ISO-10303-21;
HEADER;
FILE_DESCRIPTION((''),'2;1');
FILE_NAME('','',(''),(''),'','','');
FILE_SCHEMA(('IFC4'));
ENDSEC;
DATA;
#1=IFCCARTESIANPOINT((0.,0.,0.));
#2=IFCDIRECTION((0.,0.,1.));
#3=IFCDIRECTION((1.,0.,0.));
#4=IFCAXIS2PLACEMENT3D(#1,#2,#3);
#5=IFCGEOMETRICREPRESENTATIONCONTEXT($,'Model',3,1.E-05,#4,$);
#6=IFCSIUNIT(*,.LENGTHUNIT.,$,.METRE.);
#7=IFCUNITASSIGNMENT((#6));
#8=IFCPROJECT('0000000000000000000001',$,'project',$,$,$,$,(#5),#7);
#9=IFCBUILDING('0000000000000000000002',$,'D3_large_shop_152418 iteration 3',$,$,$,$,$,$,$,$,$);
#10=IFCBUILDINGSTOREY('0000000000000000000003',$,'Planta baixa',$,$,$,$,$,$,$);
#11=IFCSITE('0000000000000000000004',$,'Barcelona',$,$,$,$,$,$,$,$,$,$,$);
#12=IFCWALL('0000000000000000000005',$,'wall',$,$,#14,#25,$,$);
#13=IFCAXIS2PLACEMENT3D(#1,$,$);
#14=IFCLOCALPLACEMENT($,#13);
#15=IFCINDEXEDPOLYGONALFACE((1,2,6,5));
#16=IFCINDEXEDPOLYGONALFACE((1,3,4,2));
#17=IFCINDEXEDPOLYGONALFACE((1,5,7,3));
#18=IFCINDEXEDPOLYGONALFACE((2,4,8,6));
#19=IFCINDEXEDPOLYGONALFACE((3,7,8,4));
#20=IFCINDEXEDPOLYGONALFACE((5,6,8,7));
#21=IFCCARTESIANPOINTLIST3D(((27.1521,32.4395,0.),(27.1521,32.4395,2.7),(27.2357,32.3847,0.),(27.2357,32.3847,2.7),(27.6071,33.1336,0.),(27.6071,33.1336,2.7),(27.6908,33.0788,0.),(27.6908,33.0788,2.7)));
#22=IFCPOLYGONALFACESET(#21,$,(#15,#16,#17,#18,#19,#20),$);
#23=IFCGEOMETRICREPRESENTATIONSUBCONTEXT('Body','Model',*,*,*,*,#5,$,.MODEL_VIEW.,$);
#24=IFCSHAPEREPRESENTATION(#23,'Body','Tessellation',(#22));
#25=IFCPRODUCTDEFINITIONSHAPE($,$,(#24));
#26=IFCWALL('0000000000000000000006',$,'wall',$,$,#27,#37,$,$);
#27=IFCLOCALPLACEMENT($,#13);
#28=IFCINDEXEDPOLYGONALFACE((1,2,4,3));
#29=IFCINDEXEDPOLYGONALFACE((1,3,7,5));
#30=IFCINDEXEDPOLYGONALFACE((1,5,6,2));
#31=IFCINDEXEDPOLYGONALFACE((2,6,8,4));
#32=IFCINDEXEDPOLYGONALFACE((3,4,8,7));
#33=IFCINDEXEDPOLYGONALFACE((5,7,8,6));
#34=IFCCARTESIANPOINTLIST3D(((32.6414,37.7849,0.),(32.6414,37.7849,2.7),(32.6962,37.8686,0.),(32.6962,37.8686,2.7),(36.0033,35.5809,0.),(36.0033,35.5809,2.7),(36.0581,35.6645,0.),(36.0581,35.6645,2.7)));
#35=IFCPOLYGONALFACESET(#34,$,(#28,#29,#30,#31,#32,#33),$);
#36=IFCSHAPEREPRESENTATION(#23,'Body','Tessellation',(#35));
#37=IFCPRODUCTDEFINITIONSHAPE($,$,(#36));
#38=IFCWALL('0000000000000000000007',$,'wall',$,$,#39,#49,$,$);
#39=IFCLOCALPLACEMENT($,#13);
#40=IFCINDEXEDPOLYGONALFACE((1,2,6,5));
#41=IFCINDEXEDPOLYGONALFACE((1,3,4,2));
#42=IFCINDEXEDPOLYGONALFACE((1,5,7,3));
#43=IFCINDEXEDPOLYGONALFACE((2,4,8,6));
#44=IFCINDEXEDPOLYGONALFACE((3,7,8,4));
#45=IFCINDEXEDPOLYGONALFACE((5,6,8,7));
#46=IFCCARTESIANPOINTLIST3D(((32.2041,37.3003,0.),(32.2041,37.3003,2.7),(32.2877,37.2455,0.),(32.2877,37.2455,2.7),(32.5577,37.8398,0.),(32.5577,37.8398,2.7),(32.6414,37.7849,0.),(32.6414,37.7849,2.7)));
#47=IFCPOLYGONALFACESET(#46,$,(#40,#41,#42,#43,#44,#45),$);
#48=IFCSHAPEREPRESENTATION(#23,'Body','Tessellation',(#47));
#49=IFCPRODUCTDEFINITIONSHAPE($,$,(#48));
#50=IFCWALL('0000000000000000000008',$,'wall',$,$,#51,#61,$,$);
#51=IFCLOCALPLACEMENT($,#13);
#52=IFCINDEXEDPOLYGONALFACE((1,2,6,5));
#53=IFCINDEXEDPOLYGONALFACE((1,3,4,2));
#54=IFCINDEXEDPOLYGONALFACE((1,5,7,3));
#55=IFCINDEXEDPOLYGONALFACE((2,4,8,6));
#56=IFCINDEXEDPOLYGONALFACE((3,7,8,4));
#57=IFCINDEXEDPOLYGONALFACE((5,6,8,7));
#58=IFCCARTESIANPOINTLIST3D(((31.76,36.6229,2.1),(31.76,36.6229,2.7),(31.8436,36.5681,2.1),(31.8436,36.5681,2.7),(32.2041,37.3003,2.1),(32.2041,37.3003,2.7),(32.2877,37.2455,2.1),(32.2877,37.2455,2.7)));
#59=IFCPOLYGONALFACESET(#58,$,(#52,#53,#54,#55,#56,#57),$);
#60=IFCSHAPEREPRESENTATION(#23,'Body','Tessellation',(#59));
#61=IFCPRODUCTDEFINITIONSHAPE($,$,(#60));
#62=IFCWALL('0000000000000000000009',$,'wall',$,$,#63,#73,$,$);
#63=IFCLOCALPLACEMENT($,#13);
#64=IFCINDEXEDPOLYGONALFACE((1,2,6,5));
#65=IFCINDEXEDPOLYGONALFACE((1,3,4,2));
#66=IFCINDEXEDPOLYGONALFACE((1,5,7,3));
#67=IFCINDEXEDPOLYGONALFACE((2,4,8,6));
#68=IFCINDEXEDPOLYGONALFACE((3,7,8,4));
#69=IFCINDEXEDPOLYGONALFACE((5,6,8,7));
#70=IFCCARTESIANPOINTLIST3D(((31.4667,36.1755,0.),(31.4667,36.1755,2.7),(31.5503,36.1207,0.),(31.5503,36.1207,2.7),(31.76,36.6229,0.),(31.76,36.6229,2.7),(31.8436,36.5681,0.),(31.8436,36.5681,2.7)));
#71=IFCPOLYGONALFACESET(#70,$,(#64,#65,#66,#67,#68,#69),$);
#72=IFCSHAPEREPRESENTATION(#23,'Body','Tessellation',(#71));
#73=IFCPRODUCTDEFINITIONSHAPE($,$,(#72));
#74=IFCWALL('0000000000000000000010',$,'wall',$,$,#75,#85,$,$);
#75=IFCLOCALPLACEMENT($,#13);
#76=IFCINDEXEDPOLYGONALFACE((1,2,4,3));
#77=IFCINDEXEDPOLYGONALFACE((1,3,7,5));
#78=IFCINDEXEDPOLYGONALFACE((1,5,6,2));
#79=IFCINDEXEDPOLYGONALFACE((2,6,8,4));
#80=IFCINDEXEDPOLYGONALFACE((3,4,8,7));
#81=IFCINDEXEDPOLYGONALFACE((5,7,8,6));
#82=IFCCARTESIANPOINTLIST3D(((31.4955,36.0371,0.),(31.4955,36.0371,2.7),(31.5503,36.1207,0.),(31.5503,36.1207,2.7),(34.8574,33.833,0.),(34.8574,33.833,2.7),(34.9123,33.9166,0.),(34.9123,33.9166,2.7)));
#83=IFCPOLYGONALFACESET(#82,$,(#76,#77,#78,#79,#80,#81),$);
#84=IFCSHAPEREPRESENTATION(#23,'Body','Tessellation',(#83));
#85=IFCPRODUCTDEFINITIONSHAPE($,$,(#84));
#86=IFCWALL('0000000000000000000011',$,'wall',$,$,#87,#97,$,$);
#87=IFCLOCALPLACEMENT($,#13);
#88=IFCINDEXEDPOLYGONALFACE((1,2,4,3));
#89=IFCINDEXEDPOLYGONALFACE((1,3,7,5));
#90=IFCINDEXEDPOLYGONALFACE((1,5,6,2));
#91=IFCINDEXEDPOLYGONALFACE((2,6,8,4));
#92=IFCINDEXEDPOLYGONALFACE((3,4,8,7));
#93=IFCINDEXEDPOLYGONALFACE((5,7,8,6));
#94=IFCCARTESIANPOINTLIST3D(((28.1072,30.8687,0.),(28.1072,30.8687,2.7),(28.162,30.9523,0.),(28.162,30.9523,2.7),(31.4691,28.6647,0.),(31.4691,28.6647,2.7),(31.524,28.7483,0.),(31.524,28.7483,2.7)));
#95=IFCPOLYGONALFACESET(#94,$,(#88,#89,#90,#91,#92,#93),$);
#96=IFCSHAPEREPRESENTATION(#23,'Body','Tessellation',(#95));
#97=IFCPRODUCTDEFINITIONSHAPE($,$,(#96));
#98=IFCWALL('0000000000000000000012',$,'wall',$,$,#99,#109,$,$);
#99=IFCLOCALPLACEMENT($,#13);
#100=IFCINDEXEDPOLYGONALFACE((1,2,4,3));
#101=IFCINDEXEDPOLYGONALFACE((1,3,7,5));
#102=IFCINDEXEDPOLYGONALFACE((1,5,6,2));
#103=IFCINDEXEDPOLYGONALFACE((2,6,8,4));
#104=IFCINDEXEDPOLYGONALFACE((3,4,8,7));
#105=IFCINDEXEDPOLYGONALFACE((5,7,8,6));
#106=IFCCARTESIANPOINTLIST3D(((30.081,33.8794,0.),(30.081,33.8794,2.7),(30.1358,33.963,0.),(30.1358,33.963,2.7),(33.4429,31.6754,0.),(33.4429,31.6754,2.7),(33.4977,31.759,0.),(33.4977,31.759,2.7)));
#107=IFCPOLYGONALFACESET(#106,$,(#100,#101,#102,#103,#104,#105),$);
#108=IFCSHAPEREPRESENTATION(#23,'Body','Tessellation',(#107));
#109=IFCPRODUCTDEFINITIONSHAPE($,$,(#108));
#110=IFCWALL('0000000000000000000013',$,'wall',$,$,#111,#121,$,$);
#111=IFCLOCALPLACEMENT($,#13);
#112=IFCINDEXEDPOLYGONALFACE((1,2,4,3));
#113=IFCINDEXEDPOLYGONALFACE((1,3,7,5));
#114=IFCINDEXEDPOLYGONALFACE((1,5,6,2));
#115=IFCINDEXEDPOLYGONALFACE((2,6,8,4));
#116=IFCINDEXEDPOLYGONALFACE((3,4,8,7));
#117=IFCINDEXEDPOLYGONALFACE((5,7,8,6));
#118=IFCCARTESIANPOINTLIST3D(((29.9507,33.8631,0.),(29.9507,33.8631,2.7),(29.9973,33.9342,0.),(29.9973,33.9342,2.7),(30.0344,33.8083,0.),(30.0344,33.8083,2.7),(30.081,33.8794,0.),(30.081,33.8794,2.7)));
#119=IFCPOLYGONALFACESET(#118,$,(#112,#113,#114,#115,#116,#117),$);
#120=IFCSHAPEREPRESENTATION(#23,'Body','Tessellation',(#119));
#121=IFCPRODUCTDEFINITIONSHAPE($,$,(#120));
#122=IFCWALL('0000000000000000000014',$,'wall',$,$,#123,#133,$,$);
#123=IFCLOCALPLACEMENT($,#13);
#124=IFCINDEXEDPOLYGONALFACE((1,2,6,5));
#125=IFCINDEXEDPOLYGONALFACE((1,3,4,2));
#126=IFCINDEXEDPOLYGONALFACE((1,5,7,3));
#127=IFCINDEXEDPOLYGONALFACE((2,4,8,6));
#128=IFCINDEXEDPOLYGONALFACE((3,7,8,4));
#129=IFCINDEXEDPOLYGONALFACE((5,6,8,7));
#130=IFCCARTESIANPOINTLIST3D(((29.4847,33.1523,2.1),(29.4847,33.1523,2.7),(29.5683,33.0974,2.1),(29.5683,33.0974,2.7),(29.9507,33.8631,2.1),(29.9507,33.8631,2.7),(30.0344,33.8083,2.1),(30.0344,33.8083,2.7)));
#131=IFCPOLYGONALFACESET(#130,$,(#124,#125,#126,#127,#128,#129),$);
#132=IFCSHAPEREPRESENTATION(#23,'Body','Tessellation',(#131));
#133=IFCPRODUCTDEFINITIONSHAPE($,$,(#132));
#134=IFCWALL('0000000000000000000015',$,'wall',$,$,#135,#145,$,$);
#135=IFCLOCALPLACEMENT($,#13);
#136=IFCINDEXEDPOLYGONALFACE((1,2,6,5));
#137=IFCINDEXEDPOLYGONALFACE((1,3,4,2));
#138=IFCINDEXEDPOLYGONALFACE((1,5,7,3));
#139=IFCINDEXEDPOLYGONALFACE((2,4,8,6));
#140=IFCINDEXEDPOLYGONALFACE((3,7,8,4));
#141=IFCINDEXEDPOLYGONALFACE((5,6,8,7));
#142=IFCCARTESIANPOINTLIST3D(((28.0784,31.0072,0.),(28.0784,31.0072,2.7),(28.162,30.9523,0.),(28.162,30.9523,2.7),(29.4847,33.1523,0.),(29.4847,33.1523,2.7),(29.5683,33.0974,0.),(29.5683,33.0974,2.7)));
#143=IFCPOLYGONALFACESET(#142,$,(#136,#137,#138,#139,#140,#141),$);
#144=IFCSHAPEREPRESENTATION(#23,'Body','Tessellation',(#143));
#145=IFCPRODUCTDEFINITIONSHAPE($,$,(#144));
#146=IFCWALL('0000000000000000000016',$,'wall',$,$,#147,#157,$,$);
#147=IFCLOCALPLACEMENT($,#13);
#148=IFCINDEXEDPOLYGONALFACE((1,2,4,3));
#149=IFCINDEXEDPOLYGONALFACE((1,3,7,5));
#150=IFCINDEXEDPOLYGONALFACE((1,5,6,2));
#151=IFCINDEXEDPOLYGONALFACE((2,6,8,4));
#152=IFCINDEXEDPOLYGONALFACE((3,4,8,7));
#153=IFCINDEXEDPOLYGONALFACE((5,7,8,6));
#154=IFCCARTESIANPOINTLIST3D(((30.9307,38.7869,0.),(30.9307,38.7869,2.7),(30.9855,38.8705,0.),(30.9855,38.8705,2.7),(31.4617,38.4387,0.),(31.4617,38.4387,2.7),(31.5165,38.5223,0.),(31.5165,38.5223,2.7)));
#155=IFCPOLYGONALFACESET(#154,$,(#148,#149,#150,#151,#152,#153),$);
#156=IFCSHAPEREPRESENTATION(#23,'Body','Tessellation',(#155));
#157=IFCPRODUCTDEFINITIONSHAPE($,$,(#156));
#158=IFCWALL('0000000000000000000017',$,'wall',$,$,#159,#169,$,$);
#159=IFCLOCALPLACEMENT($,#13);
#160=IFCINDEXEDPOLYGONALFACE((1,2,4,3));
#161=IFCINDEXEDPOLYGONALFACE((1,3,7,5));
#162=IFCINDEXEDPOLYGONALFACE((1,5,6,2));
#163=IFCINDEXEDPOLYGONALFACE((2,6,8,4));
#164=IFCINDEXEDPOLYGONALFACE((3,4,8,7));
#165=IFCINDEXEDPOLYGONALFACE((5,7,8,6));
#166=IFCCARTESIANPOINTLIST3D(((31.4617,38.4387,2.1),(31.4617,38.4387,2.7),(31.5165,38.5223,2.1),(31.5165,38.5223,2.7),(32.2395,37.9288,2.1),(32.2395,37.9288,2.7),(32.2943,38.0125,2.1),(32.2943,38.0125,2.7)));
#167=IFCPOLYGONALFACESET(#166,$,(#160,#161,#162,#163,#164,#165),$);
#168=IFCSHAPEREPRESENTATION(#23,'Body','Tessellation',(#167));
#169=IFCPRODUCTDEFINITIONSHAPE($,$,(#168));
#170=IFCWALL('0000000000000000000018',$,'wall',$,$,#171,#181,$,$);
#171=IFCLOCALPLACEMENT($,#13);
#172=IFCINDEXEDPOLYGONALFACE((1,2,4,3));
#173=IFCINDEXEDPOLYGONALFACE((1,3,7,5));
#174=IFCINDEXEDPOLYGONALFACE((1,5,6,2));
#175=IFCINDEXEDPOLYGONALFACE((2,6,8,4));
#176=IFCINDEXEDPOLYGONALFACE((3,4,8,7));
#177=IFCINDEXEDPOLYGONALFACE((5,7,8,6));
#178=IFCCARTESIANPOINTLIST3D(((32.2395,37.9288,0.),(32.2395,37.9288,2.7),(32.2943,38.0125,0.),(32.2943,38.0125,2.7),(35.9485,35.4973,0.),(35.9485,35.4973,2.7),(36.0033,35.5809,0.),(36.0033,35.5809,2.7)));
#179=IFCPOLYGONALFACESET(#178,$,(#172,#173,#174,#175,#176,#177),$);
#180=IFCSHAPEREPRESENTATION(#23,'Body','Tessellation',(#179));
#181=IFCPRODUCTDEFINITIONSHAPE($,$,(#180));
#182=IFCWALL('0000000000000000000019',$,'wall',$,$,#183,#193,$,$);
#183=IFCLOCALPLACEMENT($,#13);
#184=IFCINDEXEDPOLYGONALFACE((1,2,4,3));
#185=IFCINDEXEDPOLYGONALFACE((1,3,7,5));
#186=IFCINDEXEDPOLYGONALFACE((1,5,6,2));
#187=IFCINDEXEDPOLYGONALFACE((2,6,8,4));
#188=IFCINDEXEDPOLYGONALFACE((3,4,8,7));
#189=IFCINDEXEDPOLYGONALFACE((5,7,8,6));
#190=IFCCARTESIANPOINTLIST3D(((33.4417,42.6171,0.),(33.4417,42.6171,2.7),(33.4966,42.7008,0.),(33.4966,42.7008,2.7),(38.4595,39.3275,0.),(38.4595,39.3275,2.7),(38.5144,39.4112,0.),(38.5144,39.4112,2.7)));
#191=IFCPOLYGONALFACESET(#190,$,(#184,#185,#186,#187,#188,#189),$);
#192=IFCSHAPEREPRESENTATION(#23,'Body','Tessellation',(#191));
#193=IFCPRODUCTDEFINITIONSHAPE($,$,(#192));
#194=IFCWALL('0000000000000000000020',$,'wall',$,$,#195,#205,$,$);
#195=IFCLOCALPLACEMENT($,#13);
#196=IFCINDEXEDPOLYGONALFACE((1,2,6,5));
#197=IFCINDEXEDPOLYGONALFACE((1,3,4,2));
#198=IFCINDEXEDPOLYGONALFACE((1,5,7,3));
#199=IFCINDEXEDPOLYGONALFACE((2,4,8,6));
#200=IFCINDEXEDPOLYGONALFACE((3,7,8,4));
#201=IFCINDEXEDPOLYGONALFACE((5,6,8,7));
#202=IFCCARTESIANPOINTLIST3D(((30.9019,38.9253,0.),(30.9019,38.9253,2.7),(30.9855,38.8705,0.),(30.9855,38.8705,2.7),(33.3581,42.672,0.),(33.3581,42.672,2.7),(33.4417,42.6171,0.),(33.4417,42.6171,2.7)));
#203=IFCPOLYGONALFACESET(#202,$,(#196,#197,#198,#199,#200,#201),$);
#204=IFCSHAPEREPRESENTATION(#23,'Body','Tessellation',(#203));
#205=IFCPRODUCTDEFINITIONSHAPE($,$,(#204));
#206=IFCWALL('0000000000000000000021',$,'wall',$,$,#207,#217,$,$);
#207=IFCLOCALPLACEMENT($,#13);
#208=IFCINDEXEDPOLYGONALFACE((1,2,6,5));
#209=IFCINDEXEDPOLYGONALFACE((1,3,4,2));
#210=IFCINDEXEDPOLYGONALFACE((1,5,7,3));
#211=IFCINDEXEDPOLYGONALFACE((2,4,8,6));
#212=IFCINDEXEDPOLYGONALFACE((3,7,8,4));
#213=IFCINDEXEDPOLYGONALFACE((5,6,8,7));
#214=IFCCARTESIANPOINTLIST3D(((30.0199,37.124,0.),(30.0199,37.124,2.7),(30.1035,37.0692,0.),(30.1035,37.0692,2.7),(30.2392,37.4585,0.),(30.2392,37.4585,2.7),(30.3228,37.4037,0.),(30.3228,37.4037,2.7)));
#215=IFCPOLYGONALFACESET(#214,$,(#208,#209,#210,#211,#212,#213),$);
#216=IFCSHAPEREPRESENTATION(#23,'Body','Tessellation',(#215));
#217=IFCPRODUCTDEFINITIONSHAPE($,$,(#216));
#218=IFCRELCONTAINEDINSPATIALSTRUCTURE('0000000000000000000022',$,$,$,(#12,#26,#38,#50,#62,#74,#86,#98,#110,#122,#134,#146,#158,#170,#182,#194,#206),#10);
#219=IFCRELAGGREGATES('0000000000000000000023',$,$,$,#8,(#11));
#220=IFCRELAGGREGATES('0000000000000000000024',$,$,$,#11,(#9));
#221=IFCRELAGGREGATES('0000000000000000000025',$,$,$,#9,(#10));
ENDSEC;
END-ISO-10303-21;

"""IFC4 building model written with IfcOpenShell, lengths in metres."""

from ifc_helpers import new_model, si_unit, frame, origin, origin_with_axes, place, context, subcontext, project, spatial, polyline, outline, extrude, element, save


model = new_model("IFC4")

# Units and contexts
model_context = context("Model", 3, precision=1e-05, world=origin_with_axes())
body_context = subcontext(model_context, "Body", "Model", "MODEL_VIEW")
ifc_project = project(units=[si_unit("LENGTHUNIT", "METRE")], contexts=[model_context])

# Site, building, storey
site = spatial("IfcSite", under=ifc_project, Name="Barcelona")
building = spatial("IfcBuilding", under=site, Name="D3_large_shop_152418 iteration 3")
storey = spatial("IfcBuildingStorey", under=building, Name="Planta baixa")

# Walls
wall_1_placement = place(None, origin_with_axes())
element("IfcWall", 1, at=wall_1_placement, inside=storey, Name="wall", context=body_context, shape_type="SweptSolid", body=[
    extrude(outline(polyline([(27.6908, 33.0788), (27.2357, 32.3847), (27.1521, 32.4395), (27.6071, 33.1336), (27.6908, 33.0788)])), origin(), (0.0, 0.0, 1.0), 2.7),
])
wall_2_placement = place(None, origin_with_axes())
element("IfcWall", 2, at=wall_2_placement, inside=storey, Name="wall", context=body_context, shape_type="SweptSolid", body=[
    extrude(outline(polyline([(36.0033, 35.5809), (32.6414, 37.7849), (32.6962, 37.8686), (36.0581, 35.6645), (36.0033, 35.5809)])), origin(), (0.0, 0.0, 1.0), 2.7),
])
wall_3_placement = place(None, origin_with_axes())
element("IfcWall", 3, at=wall_3_placement, inside=storey, Name="wall", context=body_context, shape_type="SweptSolid", body=[
    extrude(outline(polyline([(32.6414, 37.7849), (32.2877, 37.2455), (32.2041, 37.3003), (32.5577, 37.8398), (32.6414, 37.7849)])), origin(), (0.0, 0.0, 1.0), 2.7),
])
wall_4_placement = place(None, origin_with_axes())
element("IfcWall", 4, at=wall_4_placement, inside=storey, Name="wall", context=body_context, shape_type="SweptSolid", body=[
    extrude(outline(polyline([(32.2877, 37.2455), (31.8436, 36.5681), (31.76, 36.6229), (32.2041, 37.3003), (32.2877, 37.2455)])), frame((0.0, 0.0, 2.1)), (0.0, 0.0, 1.0), 0.6),
])
wall_5_placement = place(None, origin_with_axes())
element("IfcWall", 5, at=wall_5_placement, inside=storey, Name="wall", context=body_context, shape_type="SweptSolid", body=[
    extrude(outline(polyline([(31.8436, 36.5681), (31.5503, 36.1207), (31.4667, 36.1755), (31.76, 36.6229), (31.8436, 36.5681)])), origin(), (0.0, 0.0, 1.0), 2.7),
])
wall_6_placement = place(None, origin_with_axes())
element("IfcWall", 6, at=wall_6_placement, inside=storey, Name="wall", context=body_context, shape_type="SweptSolid", body=[
    extrude(outline(polyline([(31.5503, 36.1207), (34.9123, 33.9166), (34.8574, 33.833), (31.4955, 36.0371), (31.5503, 36.1207)])), origin(), (0.0, 0.0, 1.0), 2.7),
])
wall_7_placement = place(None, origin_with_axes())
element("IfcWall", 7, at=wall_7_placement, inside=storey, Name="wall", context=body_context, shape_type="SweptSolid", body=[
    extrude(outline(polyline([(28.162, 30.9523), (31.524, 28.7483), (31.4691, 28.6647), (28.1072, 30.8687), (28.162, 30.9523)])), origin(), (0.0, 0.0, 1.0), 2.7),
])
wall_8_placement = place(None, origin_with_axes())
element("IfcWall", 8, at=wall_8_placement, inside=storey, Name="wall", context=body_context, shape_type="SweptSolid", body=[
    extrude(outline(polyline([(33.4429, 31.6754), (30.081, 33.8794), (30.1358, 33.963), (33.4977, 31.759), (33.4429, 31.6754)])), origin(), (0.0, 0.0, 1.0), 2.7),
])
wall_9_placement = place(None, origin_with_axes())
element("IfcWall", 9, at=wall_9_placement, inside=storey, Name="wall", context=body_context, shape_type="SweptSolid", body=[
    extrude(outline(polyline([(30.081, 33.8794), (30.0344, 33.8083), (29.9507, 33.8631), (29.9973, 33.9342), (30.081, 33.8794)])), origin(), (0.0, 0.0, 1.0), 2.7),
])
wall_10_placement = place(None, origin_with_axes())
element("IfcWall", 10, at=wall_10_placement, inside=storey, Name="wall", context=body_context, shape_type="SweptSolid", body=[
    extrude(outline(polyline([(30.0344, 33.8083), (29.5683, 33.0974), (29.4847, 33.1523), (29.9507, 33.8631), (30.0344, 33.8083)])), frame((0.0, 0.0, 2.1)), (0.0, 0.0, 1.0), 0.6),
])
wall_11_placement = place(None, origin_with_axes())
element("IfcWall", 11, at=wall_11_placement, inside=storey, Name="wall", context=body_context, shape_type="SweptSolid", body=[
    extrude(outline(polyline([(29.5683, 33.0974), (28.162, 30.9523), (28.0784, 31.0072), (29.4847, 33.1523), (29.5683, 33.0974)])), origin(), (0.0, 0.0, 1.0), 2.7),
])
wall_12_placement = place(None, origin_with_axes())
element("IfcWall", 12, at=wall_12_placement, inside=storey, Name="wall", context=body_context, shape_type="SweptSolid", body=[
    extrude(outline(polyline([(30.9855, 38.8705), (31.5165, 38.5223), (31.4617, 38.4387), (30.9307, 38.7869), (30.9855, 38.8705)])), origin(), (0.0, 0.0, 1.0), 2.7),
])
wall_13_placement = place(None, origin_with_axes())
element("IfcWall", 13, at=wall_13_placement, inside=storey, Name="wall", context=body_context, shape_type="SweptSolid", body=[
    extrude(outline(polyline([(31.5165, 38.5223), (32.2943, 38.0125), (32.2395, 37.9288), (31.4617, 38.4387), (31.5165, 38.5223)])), frame((0.0, 0.0, 2.1)), (0.0, 0.0, 1.0), 0.6),
])
wall_14_placement = place(None, origin_with_axes())
element("IfcWall", 14, at=wall_14_placement, inside=storey, Name="wall", context=body_context, shape_type="SweptSolid", body=[
    extrude(outline(polyline([(32.2943, 38.0125), (36.0033, 35.5809), (35.9485, 35.4973), (32.2395, 37.9288), (32.2943, 38.0125)])), origin(), (0.0, 0.0, 1.0), 2.7),
])
wall_15_placement = place(None, origin_with_axes())
element("IfcWall", 15, at=wall_15_placement, inside=storey, Name="wall", context=body_context, shape_type="SweptSolid", body=[
    extrude(outline(polyline([(38.4595, 39.3275), (33.4417, 42.6171), (33.4966, 42.7008), (38.5144, 39.4112), (38.4595, 39.3275)])), origin(), (0.0, 0.0, 1.0), 2.7),
])
wall_16_placement = place(None, origin_with_axes())
element("IfcWall", 16, at=wall_16_placement, inside=storey, Name="wall", context=body_context, shape_type="SweptSolid", body=[
    extrude(outline(polyline([(33.4417, 42.6171), (30.9855, 38.8705), (30.9019, 38.9253), (33.3581, 42.672), (33.4417, 42.6171)])), origin(), (0.0, 0.0, 1.0), 2.7),
])
wall_17_placement = place(None, origin_with_axes())
element("IfcWall", 17, at=wall_17_placement, inside=storey, Name="wall", context=body_context, shape_type="SweptSolid", body=[
    extrude(outline(polyline([(30.3228, 37.4037), (30.1035, 37.0692), (30.0199, 37.124), (30.2392, 37.4585), (30.3228, 37.4037)])), origin(), (0.0, 0.0, 1.0), 2.7),
])

save(model, "model.ifc")
